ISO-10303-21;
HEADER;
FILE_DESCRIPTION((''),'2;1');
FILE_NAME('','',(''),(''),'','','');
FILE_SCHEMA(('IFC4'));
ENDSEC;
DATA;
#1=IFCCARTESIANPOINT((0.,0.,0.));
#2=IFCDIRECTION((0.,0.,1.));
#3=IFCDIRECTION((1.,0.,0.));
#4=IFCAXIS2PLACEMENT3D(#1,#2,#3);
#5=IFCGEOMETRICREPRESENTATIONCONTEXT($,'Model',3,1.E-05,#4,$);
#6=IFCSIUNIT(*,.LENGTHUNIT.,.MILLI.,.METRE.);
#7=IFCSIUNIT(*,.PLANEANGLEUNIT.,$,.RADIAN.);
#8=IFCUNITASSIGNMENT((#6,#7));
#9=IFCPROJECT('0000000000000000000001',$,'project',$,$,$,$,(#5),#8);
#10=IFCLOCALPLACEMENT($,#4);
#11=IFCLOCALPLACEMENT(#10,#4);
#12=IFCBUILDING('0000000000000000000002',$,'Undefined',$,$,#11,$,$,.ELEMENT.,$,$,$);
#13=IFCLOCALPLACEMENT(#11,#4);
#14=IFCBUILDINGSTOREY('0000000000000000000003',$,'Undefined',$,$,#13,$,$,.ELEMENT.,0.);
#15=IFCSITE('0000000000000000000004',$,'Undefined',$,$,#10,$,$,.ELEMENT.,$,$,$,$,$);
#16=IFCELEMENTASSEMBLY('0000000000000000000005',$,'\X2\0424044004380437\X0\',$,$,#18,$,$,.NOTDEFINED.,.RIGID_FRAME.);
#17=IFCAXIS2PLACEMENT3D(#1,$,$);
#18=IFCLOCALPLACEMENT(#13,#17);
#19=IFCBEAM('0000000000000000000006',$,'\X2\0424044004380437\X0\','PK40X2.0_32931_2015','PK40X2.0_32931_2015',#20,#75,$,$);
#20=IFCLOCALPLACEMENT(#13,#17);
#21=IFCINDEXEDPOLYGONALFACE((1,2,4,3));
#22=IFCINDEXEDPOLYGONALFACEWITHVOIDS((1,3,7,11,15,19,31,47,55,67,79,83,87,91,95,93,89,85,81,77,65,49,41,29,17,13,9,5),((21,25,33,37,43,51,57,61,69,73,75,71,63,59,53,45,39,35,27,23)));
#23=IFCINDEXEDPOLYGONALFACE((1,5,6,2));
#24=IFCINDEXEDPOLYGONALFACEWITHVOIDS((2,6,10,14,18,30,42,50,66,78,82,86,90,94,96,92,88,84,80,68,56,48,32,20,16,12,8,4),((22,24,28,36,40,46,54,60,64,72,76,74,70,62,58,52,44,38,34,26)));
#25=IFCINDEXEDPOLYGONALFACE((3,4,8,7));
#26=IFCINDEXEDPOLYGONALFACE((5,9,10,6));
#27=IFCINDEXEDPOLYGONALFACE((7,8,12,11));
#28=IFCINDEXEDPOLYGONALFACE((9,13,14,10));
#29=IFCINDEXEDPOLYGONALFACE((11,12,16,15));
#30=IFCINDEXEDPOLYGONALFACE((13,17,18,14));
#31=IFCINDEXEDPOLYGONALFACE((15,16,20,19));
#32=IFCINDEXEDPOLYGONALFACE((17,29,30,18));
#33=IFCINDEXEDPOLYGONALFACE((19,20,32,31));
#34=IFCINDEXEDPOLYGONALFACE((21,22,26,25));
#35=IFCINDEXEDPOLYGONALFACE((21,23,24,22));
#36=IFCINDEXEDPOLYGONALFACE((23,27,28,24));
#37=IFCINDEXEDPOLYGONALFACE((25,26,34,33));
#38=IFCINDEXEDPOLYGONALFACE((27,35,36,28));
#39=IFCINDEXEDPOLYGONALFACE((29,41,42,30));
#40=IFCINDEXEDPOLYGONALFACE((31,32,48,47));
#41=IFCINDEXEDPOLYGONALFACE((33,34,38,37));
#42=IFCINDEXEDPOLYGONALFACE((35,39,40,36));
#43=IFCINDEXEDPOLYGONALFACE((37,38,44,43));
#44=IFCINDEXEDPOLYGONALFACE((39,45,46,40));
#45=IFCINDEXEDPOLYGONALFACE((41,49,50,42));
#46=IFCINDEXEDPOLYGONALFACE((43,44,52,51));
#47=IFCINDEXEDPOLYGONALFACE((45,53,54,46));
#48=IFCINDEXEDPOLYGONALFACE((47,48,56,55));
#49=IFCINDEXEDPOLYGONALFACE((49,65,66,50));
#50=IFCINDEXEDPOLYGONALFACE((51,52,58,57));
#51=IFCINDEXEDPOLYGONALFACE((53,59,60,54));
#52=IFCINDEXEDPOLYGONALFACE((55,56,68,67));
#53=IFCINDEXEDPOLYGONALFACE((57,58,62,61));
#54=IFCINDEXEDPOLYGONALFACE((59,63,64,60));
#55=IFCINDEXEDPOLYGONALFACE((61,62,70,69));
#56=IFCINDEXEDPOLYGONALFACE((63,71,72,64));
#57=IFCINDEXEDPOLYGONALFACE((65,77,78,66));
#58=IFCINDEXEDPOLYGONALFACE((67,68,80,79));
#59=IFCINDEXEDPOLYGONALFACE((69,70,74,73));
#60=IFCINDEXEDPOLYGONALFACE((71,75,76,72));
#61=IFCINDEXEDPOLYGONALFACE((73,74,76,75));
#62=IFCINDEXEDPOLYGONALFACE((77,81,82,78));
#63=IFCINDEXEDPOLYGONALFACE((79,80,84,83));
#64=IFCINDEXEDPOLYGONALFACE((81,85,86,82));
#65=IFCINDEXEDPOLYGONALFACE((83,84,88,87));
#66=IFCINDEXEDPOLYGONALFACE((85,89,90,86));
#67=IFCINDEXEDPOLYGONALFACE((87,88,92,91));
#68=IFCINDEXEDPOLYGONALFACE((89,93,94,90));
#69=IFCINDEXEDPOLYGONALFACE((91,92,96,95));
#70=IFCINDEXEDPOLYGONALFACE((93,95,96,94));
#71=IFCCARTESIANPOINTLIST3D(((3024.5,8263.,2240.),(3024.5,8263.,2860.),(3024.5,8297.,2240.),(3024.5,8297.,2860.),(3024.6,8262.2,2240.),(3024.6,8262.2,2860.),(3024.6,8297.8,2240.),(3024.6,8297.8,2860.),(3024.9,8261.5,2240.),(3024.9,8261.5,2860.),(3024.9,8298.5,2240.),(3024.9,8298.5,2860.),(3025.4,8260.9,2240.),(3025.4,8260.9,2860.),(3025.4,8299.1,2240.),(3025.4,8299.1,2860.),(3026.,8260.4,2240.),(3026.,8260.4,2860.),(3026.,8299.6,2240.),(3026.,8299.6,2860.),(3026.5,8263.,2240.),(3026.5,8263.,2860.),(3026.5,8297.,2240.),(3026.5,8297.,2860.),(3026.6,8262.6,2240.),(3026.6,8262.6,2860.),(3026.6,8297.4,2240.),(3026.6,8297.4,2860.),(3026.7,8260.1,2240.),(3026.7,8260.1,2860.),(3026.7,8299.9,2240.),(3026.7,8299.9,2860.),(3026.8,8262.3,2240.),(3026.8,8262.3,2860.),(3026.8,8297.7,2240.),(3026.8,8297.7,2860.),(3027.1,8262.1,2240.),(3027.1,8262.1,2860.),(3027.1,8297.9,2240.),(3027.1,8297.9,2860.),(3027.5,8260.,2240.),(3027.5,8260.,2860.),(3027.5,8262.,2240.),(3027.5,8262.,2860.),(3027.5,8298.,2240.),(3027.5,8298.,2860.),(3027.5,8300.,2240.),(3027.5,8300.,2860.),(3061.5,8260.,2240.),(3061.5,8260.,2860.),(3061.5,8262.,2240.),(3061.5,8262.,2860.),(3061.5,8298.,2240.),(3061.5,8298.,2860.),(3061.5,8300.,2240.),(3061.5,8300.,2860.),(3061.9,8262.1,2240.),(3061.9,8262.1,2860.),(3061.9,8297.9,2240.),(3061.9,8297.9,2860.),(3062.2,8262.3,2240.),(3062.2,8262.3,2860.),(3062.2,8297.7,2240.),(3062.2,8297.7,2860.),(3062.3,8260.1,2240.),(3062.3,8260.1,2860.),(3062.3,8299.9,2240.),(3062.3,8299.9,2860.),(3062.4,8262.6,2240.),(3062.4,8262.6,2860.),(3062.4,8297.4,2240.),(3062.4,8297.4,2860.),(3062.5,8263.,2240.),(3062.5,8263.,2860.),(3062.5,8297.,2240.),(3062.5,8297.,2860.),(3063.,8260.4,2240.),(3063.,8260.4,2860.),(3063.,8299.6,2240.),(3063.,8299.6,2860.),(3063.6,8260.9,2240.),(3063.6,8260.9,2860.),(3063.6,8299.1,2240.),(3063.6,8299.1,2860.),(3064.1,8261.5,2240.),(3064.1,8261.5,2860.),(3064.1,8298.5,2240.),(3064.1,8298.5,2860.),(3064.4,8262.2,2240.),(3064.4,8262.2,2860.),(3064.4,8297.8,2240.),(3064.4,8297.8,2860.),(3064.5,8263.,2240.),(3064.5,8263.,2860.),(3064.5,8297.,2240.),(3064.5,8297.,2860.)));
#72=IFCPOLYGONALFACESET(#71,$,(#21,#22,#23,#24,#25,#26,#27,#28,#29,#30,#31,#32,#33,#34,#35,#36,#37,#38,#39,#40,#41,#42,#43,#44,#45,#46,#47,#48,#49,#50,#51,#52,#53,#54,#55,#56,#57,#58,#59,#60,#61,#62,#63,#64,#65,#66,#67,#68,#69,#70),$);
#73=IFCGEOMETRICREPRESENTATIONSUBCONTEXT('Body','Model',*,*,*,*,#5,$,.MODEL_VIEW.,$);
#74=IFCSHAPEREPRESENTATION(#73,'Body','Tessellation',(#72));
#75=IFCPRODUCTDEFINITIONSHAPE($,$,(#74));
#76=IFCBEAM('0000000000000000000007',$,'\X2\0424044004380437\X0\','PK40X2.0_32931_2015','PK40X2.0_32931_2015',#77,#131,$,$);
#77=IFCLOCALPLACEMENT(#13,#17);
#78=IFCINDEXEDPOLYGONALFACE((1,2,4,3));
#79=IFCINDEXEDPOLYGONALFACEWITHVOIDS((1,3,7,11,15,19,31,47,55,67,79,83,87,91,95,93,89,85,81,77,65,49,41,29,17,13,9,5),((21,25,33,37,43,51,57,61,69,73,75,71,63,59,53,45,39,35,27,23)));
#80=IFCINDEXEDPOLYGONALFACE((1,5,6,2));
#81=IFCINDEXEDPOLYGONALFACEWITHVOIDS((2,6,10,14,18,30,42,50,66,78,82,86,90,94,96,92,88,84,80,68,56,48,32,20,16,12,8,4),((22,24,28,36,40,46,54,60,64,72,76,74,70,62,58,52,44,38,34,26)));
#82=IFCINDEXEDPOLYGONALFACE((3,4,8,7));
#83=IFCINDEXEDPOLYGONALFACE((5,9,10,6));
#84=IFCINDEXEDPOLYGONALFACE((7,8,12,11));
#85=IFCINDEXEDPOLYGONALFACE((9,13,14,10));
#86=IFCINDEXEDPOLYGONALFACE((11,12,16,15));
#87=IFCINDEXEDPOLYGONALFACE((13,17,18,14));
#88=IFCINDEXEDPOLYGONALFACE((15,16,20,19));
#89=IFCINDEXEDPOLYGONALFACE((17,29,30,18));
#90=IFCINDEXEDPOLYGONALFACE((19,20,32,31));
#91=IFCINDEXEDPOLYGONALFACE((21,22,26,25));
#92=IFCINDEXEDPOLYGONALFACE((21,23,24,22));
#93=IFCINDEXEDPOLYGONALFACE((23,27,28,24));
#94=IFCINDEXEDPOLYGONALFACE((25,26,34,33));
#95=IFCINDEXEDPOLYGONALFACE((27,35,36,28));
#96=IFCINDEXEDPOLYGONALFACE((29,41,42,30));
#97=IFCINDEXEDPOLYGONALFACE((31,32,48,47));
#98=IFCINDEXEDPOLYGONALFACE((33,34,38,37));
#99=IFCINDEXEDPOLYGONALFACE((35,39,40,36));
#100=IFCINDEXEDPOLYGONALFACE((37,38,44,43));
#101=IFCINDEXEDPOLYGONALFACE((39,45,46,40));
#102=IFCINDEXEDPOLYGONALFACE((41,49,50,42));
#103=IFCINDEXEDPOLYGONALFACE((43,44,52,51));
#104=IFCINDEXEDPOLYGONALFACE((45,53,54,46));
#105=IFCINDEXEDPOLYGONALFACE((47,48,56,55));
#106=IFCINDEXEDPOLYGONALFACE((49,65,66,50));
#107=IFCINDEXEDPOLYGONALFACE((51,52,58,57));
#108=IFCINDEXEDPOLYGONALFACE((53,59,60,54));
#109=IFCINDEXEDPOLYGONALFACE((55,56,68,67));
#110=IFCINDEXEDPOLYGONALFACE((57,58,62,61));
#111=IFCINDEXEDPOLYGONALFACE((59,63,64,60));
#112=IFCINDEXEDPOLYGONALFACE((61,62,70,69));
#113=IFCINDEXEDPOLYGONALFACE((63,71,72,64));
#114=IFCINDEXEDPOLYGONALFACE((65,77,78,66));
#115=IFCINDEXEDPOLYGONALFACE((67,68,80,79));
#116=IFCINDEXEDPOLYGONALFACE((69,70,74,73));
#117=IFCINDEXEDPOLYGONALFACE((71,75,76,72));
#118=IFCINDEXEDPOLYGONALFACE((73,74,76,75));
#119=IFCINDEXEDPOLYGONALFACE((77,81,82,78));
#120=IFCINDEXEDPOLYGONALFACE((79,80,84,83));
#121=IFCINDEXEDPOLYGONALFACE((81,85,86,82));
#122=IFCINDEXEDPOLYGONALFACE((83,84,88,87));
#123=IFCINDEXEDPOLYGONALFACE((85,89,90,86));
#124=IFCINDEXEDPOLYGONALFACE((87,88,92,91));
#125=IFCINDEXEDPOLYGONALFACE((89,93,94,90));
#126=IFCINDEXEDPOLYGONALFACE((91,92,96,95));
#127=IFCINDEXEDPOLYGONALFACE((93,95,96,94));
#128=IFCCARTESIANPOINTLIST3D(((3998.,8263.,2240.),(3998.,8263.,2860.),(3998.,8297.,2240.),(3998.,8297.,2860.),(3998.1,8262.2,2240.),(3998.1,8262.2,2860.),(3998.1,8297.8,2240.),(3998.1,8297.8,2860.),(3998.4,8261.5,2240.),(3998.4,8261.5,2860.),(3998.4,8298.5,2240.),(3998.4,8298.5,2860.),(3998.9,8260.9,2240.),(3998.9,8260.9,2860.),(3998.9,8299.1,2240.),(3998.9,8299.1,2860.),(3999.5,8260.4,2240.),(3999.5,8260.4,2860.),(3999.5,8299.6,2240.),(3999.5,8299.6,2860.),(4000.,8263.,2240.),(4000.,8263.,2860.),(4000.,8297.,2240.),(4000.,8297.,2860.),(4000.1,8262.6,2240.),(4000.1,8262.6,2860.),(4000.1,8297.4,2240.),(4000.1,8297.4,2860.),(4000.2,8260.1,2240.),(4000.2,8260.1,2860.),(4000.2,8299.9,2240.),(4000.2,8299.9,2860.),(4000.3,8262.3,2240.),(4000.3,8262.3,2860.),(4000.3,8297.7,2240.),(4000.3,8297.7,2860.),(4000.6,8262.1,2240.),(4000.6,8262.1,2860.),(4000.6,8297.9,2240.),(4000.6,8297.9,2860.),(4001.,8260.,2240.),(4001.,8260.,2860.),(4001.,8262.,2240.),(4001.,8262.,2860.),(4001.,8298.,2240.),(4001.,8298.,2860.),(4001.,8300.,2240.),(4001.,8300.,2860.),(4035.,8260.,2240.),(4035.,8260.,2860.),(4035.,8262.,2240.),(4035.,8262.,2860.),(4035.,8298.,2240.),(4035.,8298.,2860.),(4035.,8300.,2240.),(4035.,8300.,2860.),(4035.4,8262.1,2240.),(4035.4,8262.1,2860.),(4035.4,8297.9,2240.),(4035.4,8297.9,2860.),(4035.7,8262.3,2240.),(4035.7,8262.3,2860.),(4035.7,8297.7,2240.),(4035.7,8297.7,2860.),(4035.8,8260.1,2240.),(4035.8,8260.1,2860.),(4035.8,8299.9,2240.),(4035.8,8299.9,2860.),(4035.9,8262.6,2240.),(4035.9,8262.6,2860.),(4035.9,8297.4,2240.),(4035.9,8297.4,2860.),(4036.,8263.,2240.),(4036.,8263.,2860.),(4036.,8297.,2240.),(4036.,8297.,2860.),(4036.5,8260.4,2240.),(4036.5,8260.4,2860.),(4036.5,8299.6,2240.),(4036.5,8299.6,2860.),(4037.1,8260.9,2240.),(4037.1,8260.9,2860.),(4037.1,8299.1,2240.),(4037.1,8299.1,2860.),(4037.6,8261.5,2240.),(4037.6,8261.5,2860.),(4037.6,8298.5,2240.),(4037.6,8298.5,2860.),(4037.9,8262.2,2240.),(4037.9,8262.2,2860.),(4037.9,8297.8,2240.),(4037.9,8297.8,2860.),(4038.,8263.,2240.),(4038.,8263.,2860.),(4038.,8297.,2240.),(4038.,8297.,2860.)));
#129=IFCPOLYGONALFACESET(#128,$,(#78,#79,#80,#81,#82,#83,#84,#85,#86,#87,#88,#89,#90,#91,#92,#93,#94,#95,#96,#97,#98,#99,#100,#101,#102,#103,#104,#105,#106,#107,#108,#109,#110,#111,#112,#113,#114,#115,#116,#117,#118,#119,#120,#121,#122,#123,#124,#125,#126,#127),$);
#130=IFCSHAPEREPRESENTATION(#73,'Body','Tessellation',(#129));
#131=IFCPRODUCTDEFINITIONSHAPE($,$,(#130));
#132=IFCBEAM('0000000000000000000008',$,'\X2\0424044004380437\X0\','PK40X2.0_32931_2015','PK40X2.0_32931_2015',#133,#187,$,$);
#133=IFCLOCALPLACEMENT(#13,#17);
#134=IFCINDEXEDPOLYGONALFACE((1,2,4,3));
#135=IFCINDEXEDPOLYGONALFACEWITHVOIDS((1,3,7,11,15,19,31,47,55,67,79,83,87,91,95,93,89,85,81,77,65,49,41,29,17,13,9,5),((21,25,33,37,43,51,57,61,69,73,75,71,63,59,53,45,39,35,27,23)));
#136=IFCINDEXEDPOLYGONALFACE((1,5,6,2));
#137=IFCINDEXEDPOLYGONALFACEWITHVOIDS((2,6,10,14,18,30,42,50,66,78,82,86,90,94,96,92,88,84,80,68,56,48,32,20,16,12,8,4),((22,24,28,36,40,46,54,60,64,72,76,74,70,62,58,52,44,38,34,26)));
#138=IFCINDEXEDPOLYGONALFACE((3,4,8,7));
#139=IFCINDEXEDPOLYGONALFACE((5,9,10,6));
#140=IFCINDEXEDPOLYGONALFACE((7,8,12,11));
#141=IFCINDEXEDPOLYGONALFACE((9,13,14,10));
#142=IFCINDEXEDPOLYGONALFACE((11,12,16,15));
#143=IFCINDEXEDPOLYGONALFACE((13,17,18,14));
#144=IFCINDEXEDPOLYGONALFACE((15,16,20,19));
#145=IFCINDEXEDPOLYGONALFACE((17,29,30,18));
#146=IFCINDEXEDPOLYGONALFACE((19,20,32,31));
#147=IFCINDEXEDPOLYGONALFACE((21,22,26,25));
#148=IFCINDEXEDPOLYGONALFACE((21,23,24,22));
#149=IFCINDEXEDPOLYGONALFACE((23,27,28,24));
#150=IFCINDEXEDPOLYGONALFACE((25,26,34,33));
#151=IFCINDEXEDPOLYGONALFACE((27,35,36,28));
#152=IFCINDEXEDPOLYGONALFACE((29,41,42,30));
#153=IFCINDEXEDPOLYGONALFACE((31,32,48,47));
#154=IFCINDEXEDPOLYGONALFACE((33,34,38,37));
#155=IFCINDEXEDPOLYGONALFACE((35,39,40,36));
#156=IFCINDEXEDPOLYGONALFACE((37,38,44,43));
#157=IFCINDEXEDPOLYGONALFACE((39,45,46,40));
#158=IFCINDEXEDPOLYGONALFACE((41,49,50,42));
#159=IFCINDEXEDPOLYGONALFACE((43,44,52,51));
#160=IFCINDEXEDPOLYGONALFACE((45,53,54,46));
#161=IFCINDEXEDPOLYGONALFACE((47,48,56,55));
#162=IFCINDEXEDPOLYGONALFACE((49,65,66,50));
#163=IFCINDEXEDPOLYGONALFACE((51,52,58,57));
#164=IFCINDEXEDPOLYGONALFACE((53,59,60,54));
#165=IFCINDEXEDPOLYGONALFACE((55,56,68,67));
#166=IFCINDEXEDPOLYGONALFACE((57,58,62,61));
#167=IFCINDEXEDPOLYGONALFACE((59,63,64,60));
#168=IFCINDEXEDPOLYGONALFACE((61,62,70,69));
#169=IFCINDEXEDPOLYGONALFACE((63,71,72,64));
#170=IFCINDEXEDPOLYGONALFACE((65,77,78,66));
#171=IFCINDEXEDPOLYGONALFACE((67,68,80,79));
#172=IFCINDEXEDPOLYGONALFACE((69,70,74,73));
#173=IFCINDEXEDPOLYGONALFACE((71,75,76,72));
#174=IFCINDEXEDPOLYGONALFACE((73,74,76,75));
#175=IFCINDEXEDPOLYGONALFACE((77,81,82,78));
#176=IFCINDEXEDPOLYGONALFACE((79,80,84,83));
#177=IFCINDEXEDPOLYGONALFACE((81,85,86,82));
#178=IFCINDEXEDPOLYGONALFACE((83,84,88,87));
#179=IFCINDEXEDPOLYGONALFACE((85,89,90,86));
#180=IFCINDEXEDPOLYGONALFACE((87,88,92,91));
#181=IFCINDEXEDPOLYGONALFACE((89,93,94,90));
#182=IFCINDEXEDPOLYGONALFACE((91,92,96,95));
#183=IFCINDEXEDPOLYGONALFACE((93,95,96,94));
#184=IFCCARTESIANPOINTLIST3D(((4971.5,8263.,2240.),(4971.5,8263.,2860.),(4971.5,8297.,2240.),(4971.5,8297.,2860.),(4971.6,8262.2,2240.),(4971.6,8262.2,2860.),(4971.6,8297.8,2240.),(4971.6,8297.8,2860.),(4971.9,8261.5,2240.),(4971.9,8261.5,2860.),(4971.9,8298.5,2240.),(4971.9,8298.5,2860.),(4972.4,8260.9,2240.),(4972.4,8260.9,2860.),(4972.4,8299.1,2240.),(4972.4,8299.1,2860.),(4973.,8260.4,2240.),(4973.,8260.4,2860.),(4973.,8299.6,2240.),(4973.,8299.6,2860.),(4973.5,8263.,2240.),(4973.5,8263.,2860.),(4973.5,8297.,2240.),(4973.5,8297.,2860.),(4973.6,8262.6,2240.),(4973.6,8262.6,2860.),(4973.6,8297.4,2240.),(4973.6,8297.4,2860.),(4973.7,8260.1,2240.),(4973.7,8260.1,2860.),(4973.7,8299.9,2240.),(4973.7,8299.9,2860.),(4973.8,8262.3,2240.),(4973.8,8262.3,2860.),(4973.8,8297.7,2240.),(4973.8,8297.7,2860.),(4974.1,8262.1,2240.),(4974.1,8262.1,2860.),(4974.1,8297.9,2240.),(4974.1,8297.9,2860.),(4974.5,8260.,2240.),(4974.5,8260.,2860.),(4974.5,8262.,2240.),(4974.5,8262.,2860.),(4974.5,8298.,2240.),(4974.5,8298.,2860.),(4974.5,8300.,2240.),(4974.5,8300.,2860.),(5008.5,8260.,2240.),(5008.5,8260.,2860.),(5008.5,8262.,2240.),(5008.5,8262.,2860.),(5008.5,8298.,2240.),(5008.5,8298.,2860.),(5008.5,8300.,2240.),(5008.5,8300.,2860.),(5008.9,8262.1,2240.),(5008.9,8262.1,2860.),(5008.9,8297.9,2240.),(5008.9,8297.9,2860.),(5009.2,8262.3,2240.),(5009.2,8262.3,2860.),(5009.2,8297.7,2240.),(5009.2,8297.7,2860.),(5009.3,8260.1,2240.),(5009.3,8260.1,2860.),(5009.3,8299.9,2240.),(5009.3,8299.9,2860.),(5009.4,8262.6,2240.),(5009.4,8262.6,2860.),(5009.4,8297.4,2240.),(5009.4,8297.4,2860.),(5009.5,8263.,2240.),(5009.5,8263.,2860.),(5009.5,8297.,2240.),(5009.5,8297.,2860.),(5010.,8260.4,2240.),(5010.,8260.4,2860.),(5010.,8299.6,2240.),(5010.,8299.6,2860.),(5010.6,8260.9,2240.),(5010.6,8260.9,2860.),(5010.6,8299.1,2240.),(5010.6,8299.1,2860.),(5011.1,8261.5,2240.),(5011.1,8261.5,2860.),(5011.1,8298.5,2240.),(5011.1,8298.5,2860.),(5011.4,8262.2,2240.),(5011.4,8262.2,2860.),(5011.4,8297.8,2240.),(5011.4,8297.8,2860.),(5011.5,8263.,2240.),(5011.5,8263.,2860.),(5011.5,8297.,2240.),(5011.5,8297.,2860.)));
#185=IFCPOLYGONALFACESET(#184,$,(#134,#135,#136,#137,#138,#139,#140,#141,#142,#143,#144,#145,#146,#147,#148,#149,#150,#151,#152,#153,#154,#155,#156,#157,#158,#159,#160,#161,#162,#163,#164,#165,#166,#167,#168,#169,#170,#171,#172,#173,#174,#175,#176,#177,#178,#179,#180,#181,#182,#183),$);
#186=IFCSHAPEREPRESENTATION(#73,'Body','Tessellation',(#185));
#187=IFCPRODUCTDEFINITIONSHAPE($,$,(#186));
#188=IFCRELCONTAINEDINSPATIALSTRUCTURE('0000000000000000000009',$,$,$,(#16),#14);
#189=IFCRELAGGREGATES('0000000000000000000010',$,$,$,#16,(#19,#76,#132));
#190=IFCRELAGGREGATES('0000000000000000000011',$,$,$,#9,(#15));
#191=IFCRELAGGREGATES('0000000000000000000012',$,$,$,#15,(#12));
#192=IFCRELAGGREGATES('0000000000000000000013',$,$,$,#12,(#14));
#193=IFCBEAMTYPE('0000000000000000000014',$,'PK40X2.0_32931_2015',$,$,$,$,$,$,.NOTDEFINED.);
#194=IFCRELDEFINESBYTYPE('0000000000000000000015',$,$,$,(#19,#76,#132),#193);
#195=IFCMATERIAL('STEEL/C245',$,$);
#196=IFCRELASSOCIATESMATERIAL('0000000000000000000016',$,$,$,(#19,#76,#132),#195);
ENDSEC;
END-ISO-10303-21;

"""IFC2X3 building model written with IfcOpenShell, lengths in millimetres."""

from ifc_helpers import new_model, si_unit, frame, origin_with_axes, origin_2d_with_axis, place, context, subcontext, project, spatial, hollow_rectangle, extrude, material, type_object, element, aggregate, save


model = new_model("IFC2X3")

# Units and contexts
model_context = context("Model", 3, precision=1e-05, world=origin_with_axes())
body_context = subcontext(model_context, "Body", "Model", "MODEL_VIEW")
ifc_project = project(units=[si_unit("LENGTHUNIT", "METRE", prefix="MILLI"), si_unit("PLANEANGLEUNIT", "RADIAN")], contexts=[model_context])

# Site, building, storey
site_placement = place(None, origin_with_axes())
site = spatial("IfcSite", under=ifc_project, at=site_placement, Name="Undefined", CompositionType="ELEMENT")
building_placement = place(site_placement, origin_with_axes())
building = spatial("IfcBuilding", under=site, at=building_placement, Name="Undefined", CompositionType="ELEMENT")
storey_placement = place(building_placement, origin_with_axes())
storey = spatial("IfcBuildingStorey", under=building, at=storey_placement, Name="Undefined", CompositionType="ELEMENT", Elevation=0.0)

# Shared definitions
ifc_material_1 = material(Name="STEEL/C245")

# Shared definitions
beam_type_1 = type_object("IfcBeamType", Name="PK40X2.0_32931_2015", PredefinedType="NOTDEFINED")

# Element assembly, beams
assembly_1_placement = place(storey_placement, origin_with_axes())
assembly_1 = element("IfcElementAssembly", 1, at=assembly_1_placement, inside=storey, Name="Фриз", AssemblyPlace="NOTDEFINED", PredefinedType="RIGID_FRAME")
beam_1_placement = place(assembly_1_placement, frame((3044.5, 8280.0, 2860.0), z_axis=(1.0, 0.0, 0.0), x_axis=(0.0, 0.0, -1.0)))
beam_1 = element("IfcBeam", 2, at=beam_1_placement, type_object=beam_type_1, material=ifc_material_1, Name="Фриз", Description="PK40X2.0_32931_2015", ObjectType="PK40X2.0_32931_2015", context=body_context, shape_type="SweptSolid", body=[
    extrude(hollow_rectangle(XDim=40.0, YDim=40.0, WallThickness=2.0, InnerFilletRadius=1.0, OuterFilletRadius=3.0, at=origin_2d_with_axis()), frame((620.0, 0.0, 0.0), z_axis=(-1.0, 0.0, 0.0), x_axis=(0.0, -1.0, 0.0)), (0.0, 0.0, 1.0), 620.0),
])
beam_2_placement = place(assembly_1_placement, frame((4018.0, 8280.0, 2860.0), z_axis=(1.0, 0.0, 0.0), x_axis=(0.0, 0.0, -1.0)))
beam_2 = element("IfcBeam", 3, at=beam_2_placement, type_object=beam_type_1, material=ifc_material_1, Name="Фриз", Description="PK40X2.0_32931_2015", ObjectType="PK40X2.0_32931_2015", context=body_context, shape_type="SweptSolid", body=[
    extrude(hollow_rectangle(XDim=40.0, YDim=40.0, WallThickness=2.0, InnerFilletRadius=1.0, OuterFilletRadius=3.0, at=origin_2d_with_axis()), frame((620.0, 0.0, 0.0), z_axis=(-1.0, 0.0, 0.0), x_axis=(0.0, -1.0, 0.0)), (0.0, 0.0, 1.0), 620.0),
])
beam_3_placement = place(assembly_1_placement, frame((4991.5, 8280.0, 2860.0), z_axis=(1.0, 0.0, 0.0), x_axis=(0.0, 0.0, -1.0)))
beam_3 = element("IfcBeam", 4, at=beam_3_placement, type_object=beam_type_1, material=ifc_material_1, Name="Фриз", Description="PK40X2.0_32931_2015", ObjectType="PK40X2.0_32931_2015", context=body_context, shape_type="SweptSolid", body=[
    extrude(hollow_rectangle(XDim=40.0, YDim=40.0, WallThickness=2.0, InnerFilletRadius=1.0, OuterFilletRadius=3.0, at=origin_2d_with_axis()), frame((620.0, 0.0, 0.0), z_axis=(-1.0, 0.0, 0.0), x_axis=(0.0, -1.0, 0.0)), (0.0, 0.0, 1.0), 620.0),
])

aggregate(assembly_1, [beam_1, beam_2, beam_3])

save(model, "model.ifc")
